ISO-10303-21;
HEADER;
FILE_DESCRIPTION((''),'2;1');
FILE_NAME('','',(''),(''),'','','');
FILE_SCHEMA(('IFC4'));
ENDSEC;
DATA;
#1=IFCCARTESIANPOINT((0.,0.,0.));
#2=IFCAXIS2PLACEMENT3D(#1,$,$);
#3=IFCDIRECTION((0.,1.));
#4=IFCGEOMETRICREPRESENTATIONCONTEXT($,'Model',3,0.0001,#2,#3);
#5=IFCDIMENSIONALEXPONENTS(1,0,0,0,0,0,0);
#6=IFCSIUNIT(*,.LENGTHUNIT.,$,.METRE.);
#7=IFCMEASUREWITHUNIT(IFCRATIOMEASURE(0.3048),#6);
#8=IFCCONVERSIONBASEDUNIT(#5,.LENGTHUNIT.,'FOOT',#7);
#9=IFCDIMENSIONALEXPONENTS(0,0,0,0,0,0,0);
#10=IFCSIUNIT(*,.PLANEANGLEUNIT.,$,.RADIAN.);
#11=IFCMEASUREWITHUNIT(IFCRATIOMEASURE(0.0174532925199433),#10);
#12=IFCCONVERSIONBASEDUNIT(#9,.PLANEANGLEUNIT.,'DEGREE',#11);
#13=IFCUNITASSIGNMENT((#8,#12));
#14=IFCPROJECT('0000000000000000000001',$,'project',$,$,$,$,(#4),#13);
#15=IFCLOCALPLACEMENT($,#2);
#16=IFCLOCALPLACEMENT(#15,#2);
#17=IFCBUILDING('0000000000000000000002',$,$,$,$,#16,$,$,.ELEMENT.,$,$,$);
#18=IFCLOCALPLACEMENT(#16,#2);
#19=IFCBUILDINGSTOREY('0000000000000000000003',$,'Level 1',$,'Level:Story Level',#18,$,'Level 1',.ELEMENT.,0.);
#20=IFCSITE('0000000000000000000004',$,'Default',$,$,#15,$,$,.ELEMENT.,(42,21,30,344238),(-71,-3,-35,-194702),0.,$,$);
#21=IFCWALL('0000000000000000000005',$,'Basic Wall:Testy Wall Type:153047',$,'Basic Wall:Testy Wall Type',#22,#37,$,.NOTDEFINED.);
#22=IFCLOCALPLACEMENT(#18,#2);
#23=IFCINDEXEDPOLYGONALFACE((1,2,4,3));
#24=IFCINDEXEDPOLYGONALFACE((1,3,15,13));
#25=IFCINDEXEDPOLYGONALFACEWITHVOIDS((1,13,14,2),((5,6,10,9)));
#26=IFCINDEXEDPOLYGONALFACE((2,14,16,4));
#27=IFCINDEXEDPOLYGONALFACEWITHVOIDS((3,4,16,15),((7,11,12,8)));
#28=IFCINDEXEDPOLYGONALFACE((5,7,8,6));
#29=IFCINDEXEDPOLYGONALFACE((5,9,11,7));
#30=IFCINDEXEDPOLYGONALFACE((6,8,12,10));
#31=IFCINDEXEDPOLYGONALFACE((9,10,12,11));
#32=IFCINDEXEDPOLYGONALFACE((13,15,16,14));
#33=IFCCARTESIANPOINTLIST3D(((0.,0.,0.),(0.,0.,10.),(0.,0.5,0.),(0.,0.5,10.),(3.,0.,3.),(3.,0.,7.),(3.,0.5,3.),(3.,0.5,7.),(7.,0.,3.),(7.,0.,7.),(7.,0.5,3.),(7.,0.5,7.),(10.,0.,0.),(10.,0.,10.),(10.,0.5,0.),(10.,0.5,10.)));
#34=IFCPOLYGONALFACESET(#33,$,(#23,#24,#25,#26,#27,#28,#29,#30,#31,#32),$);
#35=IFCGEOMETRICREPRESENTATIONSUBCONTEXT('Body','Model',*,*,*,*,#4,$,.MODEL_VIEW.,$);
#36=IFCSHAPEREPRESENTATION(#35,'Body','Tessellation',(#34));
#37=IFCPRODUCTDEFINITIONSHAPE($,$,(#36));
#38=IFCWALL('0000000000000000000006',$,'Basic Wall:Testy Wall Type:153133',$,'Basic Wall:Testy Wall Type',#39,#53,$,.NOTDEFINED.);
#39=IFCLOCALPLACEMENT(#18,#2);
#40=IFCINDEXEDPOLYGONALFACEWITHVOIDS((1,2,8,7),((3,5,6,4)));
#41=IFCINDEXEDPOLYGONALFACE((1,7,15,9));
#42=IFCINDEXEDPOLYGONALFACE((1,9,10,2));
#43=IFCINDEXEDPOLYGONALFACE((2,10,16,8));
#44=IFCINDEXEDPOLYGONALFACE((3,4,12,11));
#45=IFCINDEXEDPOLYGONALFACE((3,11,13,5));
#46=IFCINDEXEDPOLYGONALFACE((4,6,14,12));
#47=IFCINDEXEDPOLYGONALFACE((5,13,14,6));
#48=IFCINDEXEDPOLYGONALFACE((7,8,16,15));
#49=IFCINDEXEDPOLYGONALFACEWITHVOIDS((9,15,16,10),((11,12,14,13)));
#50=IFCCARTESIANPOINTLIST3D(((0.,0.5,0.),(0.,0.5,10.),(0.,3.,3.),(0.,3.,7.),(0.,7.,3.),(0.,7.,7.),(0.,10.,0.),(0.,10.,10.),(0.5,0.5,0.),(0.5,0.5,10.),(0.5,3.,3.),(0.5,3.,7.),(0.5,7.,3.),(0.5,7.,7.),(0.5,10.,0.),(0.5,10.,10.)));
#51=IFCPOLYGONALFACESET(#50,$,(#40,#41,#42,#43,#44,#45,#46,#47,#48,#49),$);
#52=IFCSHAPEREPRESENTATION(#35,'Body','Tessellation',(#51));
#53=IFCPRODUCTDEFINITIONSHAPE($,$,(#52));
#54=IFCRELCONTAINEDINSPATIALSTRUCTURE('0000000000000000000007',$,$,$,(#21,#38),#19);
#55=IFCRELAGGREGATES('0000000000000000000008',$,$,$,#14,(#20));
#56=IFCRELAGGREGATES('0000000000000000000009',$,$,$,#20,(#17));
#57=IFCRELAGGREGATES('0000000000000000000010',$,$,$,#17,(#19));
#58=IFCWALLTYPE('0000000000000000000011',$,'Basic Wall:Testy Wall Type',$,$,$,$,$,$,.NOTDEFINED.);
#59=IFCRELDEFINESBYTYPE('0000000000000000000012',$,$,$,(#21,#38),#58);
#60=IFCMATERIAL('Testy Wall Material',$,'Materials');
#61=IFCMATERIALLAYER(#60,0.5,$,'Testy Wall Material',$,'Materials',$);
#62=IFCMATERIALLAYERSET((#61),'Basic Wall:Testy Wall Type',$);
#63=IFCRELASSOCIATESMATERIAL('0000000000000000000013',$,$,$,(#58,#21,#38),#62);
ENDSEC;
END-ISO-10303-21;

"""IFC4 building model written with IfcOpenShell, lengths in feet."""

from ifc_helpers import new_model, entity, si_unit, converted_unit, direction, frame, frame_2d, origin, place, context, subcontext, project, spatial, rectangle, extrude, material, layer, layer_set, layer_usage, type_object, element, save


model = new_model("IFC4")

# Units and contexts
model_context = context("Model", 3, precision=0.0001, world=origin(), true_north=direction((0.0, 1.0)))
body_context = subcontext(model_context, "Body", "Model", "MODEL_VIEW")
ifc_project = project(units=[converted_unit("LENGTHUNIT", "FOOT", entity("IfcRatioMeasure", 0.3048), si_unit("LENGTHUNIT", "METRE"), dimensions=[1, 0, 0, 0, 0, 0, 0]), converted_unit("PLANEANGLEUNIT", "DEGREE", entity("IfcRatioMeasure", 0.0174532925199433), si_unit("PLANEANGLEUNIT", "RADIAN"), dimensions=[0, 0, 0, 0, 0, 0, 0])], contexts=[model_context])

# Site, building, storey
site_placement = place(None, origin())
site = spatial("IfcSite", under=ifc_project, at=site_placement, Name="Default", CompositionType="ELEMENT", RefLatitude=(42, 21, 30, 344238), RefLongitude=(-71, -3, -35, -194702), RefElevation=0.0)
building_placement = place(site_placement, origin())
building = spatial("IfcBuilding", under=site, at=building_placement, CompositionType="ELEMENT")
storey_placement = place(building_placement, origin())
storey = spatial("IfcBuildingStorey", under=building, at=storey_placement, Name="Level 1", ObjectType="Level:Story Level", LongName="Level 1", CompositionType="ELEMENT", Elevation=0.0)

# Walls, openings
ifc_material = material(Name="Testy Wall Material", Category="Materials")
ifc_layer = layer(ifc_material, 0.5, Name="Testy Wall Material", Category="Materials")
ifc_layer_set = layer_set([ifc_layer], Name="Basic Wall:Testy Wall Type")
ifc_layer_usage_1 = layer_usage(ifc_layer_set, "AXIS2", "NEGATIVE", 0.25)
wall_type = type_object("IfcWallType", Name="Basic Wall:Testy Wall Type", PredefinedType="NOTDEFINED", material=ifc_layer_set)
wall_1_placement = place(storey_placement, frame((0.0, 0.25, 0.0)))
wall_1 = element("IfcWall", 1, at=wall_1_placement, inside=storey, type_object=wall_type, material=ifc_layer_usage_1, Name="Basic Wall:Testy Wall Type:153047", ObjectType="Basic Wall:Testy Wall Type", PredefinedType="NOTDEFINED", context=body_context, shape_type="SweptSolid", body=[
    extrude(rectangle(XDim=10.0, YDim=0.5, at=frame_2d((5.0, 0.0), x_axis=(-1.0, 0.0))), origin(), (0.0, 0.0, 1.0), 10.0),
])
opening_1_placement = place(wall_1_placement, frame((3.0, -0.25, 3.0)))
element("IfcOpeningElement", 2, at=opening_1_placement, cuts=wall_1, ObjectType="Opening", PredefinedType="OPENING", context=body_context, shape_type="SweptSolid", body=[
    extrude(rectangle(XDim=4.0, YDim=4.0, at=frame_2d((2.0, 2.0), x_axis=(-1.0, 0.0))), frame((0.0, 0.0, 0.0), z_axis=(0.0, 1.0, 0.0), x_axis=(0.0, 0.0, 1.0)), (0.0, 0.0, 1.0), 0.5),
])
ifc_layer_usage_2 = layer_usage(ifc_layer_set, "AXIS2", "NEGATIVE", 0.25)
wall_2_placement = place(storey_placement, frame((0.25, 0.5, 0.0), z_axis=(0.0, 0.0, 1.0), x_axis=(0.0, 1.0, 0.0)))
wall_2 = element("IfcWall", 3, at=wall_2_placement, inside=storey, type_object=wall_type, material=ifc_layer_usage_2, Name="Basic Wall:Testy Wall Type:153133", ObjectType="Basic Wall:Testy Wall Type", PredefinedType="NOTDEFINED", context=body_context, shape_type="SweptSolid", body=[
    extrude(rectangle(XDim=9.5, YDim=0.5, at=frame_2d((4.75, 0.0), x_axis=(-1.0, 0.0))), origin(), (0.0, 0.0, 1.0), 10.0),
])
opening_2_placement = place(wall_2_placement, frame((6.5, 0.25, 3.0)))
element("IfcOpeningElement", 4, at=opening_2_placement, cuts=wall_2, ObjectType="Opening", PredefinedType="OPENING", context=body_context, shape_type="SweptSolid", body=[
    extrude(rectangle(XDim=4.0, YDim=4.0, at=frame_2d((2.0, 2.0), x_axis=(-1.0, 0.0))), frame((0.0, 0.0, 0.0), z_axis=(0.0, -1.0, 0.0), x_axis=(0.0, 0.0, 1.0)), (0.0, 0.0, 1.0), 0.5),
])

save(model, "model.ifc")
